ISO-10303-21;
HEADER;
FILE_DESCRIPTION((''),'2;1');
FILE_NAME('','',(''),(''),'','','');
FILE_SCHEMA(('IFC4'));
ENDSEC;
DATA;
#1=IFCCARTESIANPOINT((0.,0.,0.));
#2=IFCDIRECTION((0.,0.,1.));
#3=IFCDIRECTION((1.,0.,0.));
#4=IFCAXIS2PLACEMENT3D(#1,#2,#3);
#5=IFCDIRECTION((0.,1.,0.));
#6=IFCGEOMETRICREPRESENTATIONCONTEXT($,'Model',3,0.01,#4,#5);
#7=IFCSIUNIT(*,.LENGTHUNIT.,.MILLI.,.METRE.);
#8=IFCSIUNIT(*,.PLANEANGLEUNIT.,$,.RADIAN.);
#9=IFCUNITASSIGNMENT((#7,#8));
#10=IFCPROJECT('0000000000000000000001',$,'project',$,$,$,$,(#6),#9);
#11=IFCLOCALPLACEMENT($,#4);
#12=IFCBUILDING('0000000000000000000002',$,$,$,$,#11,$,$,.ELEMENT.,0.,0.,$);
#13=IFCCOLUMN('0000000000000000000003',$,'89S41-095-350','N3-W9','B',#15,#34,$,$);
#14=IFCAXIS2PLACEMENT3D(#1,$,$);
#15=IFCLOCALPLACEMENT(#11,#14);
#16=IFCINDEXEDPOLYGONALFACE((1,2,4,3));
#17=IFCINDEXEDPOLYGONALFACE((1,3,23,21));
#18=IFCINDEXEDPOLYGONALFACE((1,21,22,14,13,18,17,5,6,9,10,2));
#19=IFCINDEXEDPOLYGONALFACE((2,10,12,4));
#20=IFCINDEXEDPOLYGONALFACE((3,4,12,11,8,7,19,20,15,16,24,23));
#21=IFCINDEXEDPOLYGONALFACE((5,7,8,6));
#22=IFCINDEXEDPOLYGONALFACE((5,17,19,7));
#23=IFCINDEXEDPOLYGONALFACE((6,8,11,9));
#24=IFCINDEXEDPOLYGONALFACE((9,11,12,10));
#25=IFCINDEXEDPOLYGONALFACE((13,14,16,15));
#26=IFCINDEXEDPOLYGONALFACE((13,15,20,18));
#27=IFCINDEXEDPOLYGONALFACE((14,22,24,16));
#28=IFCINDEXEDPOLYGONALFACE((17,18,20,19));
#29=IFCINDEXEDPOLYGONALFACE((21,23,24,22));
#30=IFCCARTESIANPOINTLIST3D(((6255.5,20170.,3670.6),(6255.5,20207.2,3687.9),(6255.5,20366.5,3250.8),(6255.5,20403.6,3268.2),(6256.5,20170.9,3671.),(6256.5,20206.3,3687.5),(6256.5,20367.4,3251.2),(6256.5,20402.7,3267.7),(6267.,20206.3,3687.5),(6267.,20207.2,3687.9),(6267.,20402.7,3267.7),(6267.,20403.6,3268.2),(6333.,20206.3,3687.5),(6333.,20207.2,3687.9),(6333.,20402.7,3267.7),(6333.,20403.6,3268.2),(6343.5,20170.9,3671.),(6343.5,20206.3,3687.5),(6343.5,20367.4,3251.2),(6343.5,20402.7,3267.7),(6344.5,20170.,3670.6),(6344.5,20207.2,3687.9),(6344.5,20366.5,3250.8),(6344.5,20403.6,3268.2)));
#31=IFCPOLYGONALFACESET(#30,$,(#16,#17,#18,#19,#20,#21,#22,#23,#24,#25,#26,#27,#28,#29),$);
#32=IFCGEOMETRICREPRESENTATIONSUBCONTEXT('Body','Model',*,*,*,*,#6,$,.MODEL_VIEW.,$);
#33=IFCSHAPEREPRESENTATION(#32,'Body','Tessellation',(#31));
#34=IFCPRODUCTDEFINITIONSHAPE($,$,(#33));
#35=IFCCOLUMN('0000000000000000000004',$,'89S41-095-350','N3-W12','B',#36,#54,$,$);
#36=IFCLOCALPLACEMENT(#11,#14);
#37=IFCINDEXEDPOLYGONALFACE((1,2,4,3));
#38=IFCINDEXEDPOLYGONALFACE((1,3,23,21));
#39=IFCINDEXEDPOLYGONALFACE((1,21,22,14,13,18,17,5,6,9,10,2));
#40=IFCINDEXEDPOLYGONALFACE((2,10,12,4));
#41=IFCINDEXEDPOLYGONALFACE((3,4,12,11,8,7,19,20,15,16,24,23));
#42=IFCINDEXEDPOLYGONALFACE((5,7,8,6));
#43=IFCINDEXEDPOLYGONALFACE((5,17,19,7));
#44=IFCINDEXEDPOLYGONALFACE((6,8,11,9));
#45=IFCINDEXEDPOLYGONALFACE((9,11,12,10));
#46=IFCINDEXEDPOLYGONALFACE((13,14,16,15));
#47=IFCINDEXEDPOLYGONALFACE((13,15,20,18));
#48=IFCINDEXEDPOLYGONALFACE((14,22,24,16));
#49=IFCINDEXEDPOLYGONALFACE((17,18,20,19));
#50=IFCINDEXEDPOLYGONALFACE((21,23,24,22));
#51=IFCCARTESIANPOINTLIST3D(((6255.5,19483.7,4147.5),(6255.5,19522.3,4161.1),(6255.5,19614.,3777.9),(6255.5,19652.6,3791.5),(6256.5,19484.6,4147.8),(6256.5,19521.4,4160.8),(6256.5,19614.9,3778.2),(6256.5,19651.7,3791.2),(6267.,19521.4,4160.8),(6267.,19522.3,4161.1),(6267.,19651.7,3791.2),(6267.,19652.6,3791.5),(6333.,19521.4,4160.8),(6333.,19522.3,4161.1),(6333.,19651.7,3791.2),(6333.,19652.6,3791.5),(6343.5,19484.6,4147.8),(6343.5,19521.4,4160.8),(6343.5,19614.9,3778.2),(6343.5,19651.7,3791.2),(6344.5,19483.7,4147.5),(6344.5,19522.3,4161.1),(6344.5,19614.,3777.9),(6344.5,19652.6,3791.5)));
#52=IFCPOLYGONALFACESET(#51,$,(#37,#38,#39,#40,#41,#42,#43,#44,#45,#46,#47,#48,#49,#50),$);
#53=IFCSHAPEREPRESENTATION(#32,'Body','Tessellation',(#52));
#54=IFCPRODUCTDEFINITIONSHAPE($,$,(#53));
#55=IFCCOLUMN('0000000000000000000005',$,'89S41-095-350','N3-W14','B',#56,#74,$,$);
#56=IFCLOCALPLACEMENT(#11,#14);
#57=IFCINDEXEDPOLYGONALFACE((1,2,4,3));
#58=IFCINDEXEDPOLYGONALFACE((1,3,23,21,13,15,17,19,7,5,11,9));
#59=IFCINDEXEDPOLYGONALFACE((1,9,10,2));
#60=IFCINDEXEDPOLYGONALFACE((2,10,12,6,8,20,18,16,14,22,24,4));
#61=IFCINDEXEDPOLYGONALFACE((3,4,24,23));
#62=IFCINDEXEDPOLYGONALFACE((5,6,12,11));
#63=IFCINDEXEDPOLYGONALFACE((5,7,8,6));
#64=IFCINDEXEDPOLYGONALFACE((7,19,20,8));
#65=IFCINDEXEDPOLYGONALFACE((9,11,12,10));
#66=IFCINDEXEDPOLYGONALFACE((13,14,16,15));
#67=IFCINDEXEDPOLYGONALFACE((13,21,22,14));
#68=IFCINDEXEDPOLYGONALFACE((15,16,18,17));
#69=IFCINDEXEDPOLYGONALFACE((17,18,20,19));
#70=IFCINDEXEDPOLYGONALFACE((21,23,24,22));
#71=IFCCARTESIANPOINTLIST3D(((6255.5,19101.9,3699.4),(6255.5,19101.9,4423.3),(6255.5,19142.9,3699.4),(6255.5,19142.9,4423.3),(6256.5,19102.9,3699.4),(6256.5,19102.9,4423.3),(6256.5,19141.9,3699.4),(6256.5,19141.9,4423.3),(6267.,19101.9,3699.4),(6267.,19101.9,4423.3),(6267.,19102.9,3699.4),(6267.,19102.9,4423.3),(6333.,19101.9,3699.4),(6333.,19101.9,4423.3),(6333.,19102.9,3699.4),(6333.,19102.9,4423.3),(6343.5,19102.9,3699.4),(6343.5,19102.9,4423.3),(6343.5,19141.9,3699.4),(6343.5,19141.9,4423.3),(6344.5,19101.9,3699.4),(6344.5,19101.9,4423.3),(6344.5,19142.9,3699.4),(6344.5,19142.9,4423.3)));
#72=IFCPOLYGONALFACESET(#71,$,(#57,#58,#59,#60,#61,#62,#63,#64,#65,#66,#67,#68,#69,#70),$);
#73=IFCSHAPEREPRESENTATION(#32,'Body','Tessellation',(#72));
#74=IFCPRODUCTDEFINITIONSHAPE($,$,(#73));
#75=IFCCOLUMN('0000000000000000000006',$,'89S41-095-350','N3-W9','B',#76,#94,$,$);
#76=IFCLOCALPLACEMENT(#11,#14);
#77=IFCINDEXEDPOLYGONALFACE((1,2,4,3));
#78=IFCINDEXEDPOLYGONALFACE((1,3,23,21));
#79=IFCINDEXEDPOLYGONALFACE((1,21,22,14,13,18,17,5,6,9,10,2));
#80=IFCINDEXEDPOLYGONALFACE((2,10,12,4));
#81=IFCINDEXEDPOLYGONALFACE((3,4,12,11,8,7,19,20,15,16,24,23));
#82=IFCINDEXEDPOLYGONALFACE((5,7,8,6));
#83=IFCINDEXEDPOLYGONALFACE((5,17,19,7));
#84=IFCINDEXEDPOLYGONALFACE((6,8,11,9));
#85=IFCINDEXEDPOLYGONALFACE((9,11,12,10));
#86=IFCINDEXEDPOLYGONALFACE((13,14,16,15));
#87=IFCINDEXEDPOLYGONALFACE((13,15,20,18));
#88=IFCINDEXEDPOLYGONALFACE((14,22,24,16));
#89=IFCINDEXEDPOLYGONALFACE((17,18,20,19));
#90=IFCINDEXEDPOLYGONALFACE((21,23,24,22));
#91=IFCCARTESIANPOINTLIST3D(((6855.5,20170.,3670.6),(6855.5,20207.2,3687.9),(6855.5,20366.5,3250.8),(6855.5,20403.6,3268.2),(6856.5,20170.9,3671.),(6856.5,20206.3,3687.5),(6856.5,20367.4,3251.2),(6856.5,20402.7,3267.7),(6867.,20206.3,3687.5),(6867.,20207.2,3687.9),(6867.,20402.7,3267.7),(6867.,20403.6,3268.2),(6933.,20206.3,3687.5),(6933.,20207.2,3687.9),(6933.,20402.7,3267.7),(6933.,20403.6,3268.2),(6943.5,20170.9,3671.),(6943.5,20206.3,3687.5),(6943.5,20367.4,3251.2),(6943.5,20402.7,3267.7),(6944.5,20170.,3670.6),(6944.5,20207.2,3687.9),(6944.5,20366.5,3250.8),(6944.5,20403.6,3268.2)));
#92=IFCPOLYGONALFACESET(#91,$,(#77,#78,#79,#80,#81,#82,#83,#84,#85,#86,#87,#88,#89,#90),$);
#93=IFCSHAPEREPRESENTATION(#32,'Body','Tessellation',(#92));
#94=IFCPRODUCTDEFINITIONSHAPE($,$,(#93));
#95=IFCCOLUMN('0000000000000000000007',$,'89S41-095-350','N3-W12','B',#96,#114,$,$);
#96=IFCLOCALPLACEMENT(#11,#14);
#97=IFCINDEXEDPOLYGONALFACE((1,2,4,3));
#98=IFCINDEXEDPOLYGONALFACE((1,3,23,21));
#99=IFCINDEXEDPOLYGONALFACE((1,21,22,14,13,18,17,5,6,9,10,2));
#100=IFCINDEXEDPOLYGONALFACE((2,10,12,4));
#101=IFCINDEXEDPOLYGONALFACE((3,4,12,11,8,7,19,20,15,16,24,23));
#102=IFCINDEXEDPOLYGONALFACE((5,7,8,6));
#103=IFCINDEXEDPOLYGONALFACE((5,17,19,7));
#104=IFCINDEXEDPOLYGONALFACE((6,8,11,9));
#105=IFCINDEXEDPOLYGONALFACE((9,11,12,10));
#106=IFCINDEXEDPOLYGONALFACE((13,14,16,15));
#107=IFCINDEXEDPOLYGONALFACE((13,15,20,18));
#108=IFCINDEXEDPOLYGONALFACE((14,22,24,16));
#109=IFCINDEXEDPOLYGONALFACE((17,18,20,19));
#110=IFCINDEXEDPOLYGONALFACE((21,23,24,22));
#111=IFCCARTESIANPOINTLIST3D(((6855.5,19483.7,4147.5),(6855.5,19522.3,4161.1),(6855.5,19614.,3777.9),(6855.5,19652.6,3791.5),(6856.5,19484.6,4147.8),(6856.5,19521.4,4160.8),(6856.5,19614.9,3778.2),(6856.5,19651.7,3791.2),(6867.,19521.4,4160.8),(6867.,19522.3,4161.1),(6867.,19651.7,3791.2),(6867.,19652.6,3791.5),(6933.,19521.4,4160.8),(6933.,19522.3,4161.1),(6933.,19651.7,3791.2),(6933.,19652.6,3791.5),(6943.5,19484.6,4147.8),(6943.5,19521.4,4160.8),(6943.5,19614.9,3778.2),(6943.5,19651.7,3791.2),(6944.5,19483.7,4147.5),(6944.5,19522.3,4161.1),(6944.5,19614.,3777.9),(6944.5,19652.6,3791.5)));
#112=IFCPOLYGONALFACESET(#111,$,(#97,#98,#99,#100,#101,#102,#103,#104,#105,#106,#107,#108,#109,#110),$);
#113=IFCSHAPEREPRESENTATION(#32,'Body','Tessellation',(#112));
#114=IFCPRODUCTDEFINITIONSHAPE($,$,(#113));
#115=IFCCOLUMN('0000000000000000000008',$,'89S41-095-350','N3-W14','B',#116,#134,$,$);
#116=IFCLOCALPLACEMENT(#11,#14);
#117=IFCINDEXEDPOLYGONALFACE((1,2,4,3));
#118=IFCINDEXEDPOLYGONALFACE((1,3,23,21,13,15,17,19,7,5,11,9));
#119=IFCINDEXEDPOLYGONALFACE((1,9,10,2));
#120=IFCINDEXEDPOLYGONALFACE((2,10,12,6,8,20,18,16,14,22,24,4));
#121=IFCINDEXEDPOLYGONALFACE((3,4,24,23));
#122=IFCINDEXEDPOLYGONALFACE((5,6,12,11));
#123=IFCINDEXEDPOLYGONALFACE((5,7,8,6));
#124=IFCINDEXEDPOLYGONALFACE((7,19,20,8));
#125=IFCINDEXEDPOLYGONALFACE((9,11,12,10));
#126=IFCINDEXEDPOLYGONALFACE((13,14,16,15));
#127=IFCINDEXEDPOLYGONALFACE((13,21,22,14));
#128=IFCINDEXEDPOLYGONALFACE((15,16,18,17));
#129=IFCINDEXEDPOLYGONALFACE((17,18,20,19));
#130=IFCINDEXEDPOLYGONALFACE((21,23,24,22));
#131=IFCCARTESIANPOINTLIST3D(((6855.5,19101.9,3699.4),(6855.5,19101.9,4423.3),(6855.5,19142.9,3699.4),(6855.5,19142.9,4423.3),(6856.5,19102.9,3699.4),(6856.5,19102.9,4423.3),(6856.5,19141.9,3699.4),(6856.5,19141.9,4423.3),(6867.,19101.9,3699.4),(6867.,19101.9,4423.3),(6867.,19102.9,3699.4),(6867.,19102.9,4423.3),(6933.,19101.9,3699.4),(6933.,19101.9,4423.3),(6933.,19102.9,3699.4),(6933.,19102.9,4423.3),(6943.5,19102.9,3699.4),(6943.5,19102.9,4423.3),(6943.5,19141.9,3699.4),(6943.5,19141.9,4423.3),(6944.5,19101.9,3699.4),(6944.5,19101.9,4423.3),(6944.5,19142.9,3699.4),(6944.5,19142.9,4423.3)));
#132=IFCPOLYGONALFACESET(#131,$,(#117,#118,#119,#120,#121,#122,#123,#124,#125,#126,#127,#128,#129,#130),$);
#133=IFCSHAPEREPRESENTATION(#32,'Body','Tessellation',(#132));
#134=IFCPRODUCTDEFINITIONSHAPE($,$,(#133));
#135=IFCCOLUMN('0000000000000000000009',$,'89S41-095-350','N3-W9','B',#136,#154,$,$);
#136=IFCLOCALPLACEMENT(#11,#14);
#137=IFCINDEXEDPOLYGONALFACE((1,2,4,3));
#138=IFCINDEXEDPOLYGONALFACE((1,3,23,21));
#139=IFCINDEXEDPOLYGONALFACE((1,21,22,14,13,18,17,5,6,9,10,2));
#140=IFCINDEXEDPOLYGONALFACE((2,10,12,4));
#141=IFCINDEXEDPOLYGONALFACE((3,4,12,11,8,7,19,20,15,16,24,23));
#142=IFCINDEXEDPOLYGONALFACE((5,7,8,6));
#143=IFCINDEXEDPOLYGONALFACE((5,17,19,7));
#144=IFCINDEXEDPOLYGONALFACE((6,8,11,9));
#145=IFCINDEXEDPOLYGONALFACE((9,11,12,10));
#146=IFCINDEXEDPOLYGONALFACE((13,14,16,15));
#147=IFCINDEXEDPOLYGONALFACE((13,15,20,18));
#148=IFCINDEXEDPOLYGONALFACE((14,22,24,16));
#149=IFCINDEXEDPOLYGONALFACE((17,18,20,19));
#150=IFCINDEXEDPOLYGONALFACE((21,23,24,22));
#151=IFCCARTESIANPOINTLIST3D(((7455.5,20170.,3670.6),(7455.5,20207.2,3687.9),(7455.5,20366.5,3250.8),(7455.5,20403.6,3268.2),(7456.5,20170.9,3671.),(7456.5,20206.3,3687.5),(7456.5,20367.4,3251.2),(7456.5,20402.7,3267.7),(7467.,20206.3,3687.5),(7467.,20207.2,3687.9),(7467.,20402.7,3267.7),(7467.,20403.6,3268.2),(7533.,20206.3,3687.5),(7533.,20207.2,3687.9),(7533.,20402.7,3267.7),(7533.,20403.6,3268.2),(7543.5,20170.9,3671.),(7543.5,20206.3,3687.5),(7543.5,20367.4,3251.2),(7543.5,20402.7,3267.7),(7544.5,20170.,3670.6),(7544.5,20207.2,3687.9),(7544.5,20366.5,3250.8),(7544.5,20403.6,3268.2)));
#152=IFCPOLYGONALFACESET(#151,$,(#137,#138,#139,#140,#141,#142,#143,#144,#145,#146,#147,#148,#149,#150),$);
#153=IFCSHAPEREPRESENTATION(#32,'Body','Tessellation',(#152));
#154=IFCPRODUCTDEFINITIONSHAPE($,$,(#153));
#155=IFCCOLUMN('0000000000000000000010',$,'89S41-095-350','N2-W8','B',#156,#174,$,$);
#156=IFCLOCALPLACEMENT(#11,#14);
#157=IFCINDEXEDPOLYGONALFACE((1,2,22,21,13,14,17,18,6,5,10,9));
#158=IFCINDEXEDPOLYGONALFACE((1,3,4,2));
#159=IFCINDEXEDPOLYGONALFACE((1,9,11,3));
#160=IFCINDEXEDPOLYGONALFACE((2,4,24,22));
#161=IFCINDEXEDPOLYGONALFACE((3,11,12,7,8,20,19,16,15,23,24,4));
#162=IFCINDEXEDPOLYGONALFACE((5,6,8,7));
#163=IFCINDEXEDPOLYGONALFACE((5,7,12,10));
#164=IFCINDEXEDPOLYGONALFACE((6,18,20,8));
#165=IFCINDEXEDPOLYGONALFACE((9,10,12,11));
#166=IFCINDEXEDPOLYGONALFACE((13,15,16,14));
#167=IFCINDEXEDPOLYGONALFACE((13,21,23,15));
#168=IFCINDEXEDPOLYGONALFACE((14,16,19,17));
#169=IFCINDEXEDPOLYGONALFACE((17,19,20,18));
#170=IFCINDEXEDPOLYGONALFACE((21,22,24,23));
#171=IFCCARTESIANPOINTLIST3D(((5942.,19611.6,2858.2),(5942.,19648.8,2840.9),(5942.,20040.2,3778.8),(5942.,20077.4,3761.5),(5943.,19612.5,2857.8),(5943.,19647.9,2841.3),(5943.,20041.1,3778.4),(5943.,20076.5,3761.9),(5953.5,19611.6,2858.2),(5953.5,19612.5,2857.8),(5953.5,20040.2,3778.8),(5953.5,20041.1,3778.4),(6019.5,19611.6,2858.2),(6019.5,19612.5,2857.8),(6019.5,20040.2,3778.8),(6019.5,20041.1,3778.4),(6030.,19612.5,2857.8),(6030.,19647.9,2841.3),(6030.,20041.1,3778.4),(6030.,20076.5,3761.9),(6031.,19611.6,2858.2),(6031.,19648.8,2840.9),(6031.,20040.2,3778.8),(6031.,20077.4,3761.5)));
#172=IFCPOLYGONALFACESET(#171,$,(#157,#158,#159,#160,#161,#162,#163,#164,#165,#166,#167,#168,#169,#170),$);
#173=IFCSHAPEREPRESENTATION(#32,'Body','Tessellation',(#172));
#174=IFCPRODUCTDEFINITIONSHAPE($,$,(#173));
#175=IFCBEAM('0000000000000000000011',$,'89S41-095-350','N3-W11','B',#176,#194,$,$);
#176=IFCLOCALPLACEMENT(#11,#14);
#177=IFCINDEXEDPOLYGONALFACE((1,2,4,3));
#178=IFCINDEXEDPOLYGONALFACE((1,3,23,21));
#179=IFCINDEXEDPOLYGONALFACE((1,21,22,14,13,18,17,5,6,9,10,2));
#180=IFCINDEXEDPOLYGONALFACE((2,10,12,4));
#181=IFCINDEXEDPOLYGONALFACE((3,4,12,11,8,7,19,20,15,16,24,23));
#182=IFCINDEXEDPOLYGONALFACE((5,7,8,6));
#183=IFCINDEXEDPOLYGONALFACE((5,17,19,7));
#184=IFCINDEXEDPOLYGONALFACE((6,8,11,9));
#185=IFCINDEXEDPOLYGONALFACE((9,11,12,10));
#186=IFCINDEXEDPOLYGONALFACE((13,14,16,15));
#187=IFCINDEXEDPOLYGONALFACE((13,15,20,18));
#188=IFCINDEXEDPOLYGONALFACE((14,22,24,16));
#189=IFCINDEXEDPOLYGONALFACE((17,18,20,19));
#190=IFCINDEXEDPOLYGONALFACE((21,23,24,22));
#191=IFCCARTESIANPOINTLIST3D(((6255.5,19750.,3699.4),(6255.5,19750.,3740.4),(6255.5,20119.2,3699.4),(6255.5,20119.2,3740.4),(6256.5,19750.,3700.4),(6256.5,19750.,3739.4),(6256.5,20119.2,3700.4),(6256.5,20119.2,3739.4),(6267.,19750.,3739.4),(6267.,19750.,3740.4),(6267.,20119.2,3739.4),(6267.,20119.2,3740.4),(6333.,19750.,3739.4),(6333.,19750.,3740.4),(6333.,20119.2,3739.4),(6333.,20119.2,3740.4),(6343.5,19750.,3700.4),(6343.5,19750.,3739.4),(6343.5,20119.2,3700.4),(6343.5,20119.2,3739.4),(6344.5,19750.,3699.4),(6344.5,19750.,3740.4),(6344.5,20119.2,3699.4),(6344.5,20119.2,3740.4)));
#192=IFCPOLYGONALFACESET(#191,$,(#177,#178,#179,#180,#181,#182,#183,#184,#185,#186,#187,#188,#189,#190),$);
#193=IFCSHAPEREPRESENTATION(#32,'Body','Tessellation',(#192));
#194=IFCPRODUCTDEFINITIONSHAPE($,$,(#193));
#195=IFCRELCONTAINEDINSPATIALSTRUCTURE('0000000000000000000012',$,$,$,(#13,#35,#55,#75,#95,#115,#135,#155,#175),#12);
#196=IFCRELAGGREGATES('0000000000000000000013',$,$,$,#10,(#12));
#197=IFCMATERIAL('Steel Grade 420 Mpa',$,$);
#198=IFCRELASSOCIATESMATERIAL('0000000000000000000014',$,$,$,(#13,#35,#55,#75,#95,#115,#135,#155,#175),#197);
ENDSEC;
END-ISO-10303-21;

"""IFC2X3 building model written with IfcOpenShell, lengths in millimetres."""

from ifc_helpers import new_model, si_unit, direction, frame, origin, origin_with_axes, origin_2d_with_axis, place, context, subcontext, project, spatial, c_section, extrude, source, transform, mapped, material, element, save


model = new_model("IFC2X3")

# Units and contexts
model_context = context("Model", 3, precision=0.01, world=origin_with_axes(), true_north=direction((0.0, 1.0, 0.0)))
body_context = subcontext(model_context, "Body", "Model", "MODEL_VIEW")
ifc_project = project(units=[si_unit("LENGTHUNIT", "METRE", prefix="MILLI"), si_unit("PLANEANGLEUNIT", "RADIAN")], contexts=[model_context])

# Building
building_placement = place(None, origin_with_axes())
building = spatial("IfcBuilding", under=ifc_project, at=building_placement, CompositionType="ELEMENT", ElevationOfRefHeight=0.0, ElevationOfTerrain=0.0)

# Columns
ifc_material = material(Name="Steel Grade 420 Mpa")
shared_shape_1 = source(origin(), body_context, "Body", "SweptSolid", [
    extrude(c_section(Depth=89.0, Width=41.0, WallThickness=1.0, Girth=11.5, at=origin_2d_with_axis()), origin_with_axes(), (0.0, 0.0, 1.0), 463.5),
])
column_1_placement = place(None, frame((6300.0, 20385.1, 3259.5), z_axis=(0.0, -0.423875, 0.905721), x_axis=(0.0, 0.905721, 0.423875)))
element("IfcColumn", 1, at=column_1_placement, inside=building, material=ifc_material, Name="89S41-095-350", Description="N3-W9", ObjectType="B", context=body_context, shape_type="MappedRepresentation", body=[
    mapped(shared_shape_1, transform((0.0, 0.0, 0.0), scale=1.0)),
])
shared_shape_2 = source(origin(), body_context, "Body", "SweptSolid", [
    extrude(c_section(Depth=89.0, Width=41.0, WallThickness=1.0, Girth=11.5, at=origin_2d_with_axis()), origin_with_axes(), (0.0, 0.0, 1.0), 391.9),
])
column_2_placement = place(None, frame((6300.0, 19633.3, 3784.7), z_axis=(0.0, -0.33255, 0.943086), x_axis=(0.0, 0.943086, 0.33255)))
element("IfcColumn", 2, at=column_2_placement, inside=building, material=ifc_material, Name="89S41-095-350", Description="N3-W12", ObjectType="B", context=body_context, shape_type="MappedRepresentation", body=[
    mapped(shared_shape_2, transform((0.0, 0.0, 0.0), scale=1.0)),
])
shared_shape_3 = source(origin(), body_context, "Body", "SweptSolid", [
    extrude(c_section(Depth=89.0, Width=41.0, WallThickness=1.0, Girth=11.5, at=origin_2d_with_axis()), origin_with_axes(), (0.0, 0.0, 1.0), 723.9),
])
column_3_placement = place(None, frame((6300.0, 19122.4, 4423.3), z_axis=(0.0, 0.0, -1.0), x_axis=(0.0, -1.0, 0.0)))
element("IfcColumn", 3, at=column_3_placement, inside=building, material=ifc_material, Name="89S41-095-350", Description="N3-W14", ObjectType="B", context=body_context, shape_type="MappedRepresentation", body=[
    mapped(shared_shape_3, transform((0.0, 0.0, 0.0), scale=1.0)),
])
shared_shape_4 = source(origin(), body_context, "Body", "SweptSolid", [
    extrude(c_section(Depth=89.0, Width=41.0, WallThickness=1.0, Girth=11.5, at=origin_2d_with_axis()), origin_with_axes(), (0.0, 0.0, 1.0), 463.5),
])
column_4_placement = place(None, frame((6900.0, 20385.1, 3259.5), z_axis=(0.0, -0.423875, 0.905721), x_axis=(0.0, 0.905721, 0.423875)))
element("IfcColumn", 4, at=column_4_placement, inside=building, material=ifc_material, Name="89S41-095-350", Description="N3-W9", ObjectType="B", context=body_context, shape_type="MappedRepresentation", body=[
    mapped(shared_shape_4, transform((0.0, 0.0, 0.0), scale=1.0)),
])
shared_shape_5 = source(origin(), body_context, "Body", "SweptSolid", [
    extrude(c_section(Depth=89.0, Width=41.0, WallThickness=1.0, Girth=11.5, at=origin_2d_with_axis()), origin_with_axes(), (0.0, 0.0, 1.0), 391.9),
])
column_5_placement = place(None, frame((6900.0, 19633.3, 3784.7), z_axis=(0.0, -0.33255, 0.943086), x_axis=(0.0, 0.943086, 0.33255)))
element("IfcColumn", 5, at=column_5_placement, inside=building, material=ifc_material, Name="89S41-095-350", Description="N3-W12", ObjectType="B", context=body_context, shape_type="MappedRepresentation", body=[
    mapped(shared_shape_5, transform((0.0, 0.0, 0.0), scale=1.0)),
])
shared_shape_6 = source(origin(), body_context, "Body", "SweptSolid", [
    extrude(c_section(Depth=89.0, Width=41.0, WallThickness=1.0, Girth=11.5, at=origin_2d_with_axis()), origin_with_axes(), (0.0, 0.0, 1.0), 723.9),
])
column_6_placement = place(None, frame((6900.0, 19122.4, 4423.3), z_axis=(0.0, 0.0, -1.0), x_axis=(0.0, -1.0, 0.0)))
element("IfcColumn", 6, at=column_6_placement, inside=building, material=ifc_material, Name="89S41-095-350", Description="N3-W14", ObjectType="B", context=body_context, shape_type="MappedRepresentation", body=[
    mapped(shared_shape_6, transform((0.0, 0.0, 0.0), scale=1.0)),
])
shared_shape_7 = source(origin(), body_context, "Body", "SweptSolid", [
    extrude(c_section(Depth=89.0, Width=41.0, WallThickness=1.0, Girth=11.5, at=origin_2d_with_axis()), origin_with_axes(), (0.0, 0.0, 1.0), 463.5),
])
column_7_placement = place(None, frame((7500.0, 20385.1, 3259.5), z_axis=(0.0, -0.423875, 0.905721), x_axis=(0.0, 0.905721, 0.423875)))
element("IfcColumn", 7, at=column_7_placement, inside=building, material=ifc_material, Name="89S41-095-350", Description="N3-W9", ObjectType="B", context=body_context, shape_type="MappedRepresentation", body=[
    mapped(shared_shape_7, transform((0.0, 0.0, 0.0), scale=1.0)),
])
shared_shape_8 = source(origin(), body_context, "Body", "SweptSolid", [
    extrude(c_section(Depth=89.0, Width=41.0, WallThickness=1.0, Girth=11.5, at=origin_2d_with_axis()), origin_with_axes(), (0.0, 0.0, 1.0), 1015.5),
])
column_8_placement = place(None, frame((5986.5, 20058.8, 3770.1), z_axis=(0.0, -0.422026, -0.906584), x_axis=(0.0, -0.906584, 0.422026)))
element("IfcColumn", 8, at=column_8_placement, inside=building, material=ifc_material, Name="89S41-095-350", Description="N2-W8", ObjectType="B", context=body_context, shape_type="MappedRepresentation", body=[
    mapped(shared_shape_8, transform((0.0, 0.0, 0.0), scale=1.0)),
])

# Beam
shared_shape_9 = source(origin(), body_context, "Body", "SweptSolid", [
    extrude(c_section(Depth=89.0, Width=41.0, WallThickness=1.0, Girth=11.5, at=origin_2d_with_axis()), origin_with_axes(), (0.0, 0.0, 1.0), 369.2),
])
beam_1_placement = place(None, frame((6300.0, 20119.2, 3719.9), z_axis=(0.0, -1.0, 0.0), x_axis=(0.0, 0.0, 1.0)))
element("IfcBeam", 9, at=beam_1_placement, inside=building, material=ifc_material, Name="89S41-095-350", Description="N3-W11", ObjectType="B", context=body_context, shape_type="MappedRepresentation", body=[
    mapped(shared_shape_9, transform((0.0, 0.0, 0.0), scale=1.0)),
])

save(model, "model.ifc")
